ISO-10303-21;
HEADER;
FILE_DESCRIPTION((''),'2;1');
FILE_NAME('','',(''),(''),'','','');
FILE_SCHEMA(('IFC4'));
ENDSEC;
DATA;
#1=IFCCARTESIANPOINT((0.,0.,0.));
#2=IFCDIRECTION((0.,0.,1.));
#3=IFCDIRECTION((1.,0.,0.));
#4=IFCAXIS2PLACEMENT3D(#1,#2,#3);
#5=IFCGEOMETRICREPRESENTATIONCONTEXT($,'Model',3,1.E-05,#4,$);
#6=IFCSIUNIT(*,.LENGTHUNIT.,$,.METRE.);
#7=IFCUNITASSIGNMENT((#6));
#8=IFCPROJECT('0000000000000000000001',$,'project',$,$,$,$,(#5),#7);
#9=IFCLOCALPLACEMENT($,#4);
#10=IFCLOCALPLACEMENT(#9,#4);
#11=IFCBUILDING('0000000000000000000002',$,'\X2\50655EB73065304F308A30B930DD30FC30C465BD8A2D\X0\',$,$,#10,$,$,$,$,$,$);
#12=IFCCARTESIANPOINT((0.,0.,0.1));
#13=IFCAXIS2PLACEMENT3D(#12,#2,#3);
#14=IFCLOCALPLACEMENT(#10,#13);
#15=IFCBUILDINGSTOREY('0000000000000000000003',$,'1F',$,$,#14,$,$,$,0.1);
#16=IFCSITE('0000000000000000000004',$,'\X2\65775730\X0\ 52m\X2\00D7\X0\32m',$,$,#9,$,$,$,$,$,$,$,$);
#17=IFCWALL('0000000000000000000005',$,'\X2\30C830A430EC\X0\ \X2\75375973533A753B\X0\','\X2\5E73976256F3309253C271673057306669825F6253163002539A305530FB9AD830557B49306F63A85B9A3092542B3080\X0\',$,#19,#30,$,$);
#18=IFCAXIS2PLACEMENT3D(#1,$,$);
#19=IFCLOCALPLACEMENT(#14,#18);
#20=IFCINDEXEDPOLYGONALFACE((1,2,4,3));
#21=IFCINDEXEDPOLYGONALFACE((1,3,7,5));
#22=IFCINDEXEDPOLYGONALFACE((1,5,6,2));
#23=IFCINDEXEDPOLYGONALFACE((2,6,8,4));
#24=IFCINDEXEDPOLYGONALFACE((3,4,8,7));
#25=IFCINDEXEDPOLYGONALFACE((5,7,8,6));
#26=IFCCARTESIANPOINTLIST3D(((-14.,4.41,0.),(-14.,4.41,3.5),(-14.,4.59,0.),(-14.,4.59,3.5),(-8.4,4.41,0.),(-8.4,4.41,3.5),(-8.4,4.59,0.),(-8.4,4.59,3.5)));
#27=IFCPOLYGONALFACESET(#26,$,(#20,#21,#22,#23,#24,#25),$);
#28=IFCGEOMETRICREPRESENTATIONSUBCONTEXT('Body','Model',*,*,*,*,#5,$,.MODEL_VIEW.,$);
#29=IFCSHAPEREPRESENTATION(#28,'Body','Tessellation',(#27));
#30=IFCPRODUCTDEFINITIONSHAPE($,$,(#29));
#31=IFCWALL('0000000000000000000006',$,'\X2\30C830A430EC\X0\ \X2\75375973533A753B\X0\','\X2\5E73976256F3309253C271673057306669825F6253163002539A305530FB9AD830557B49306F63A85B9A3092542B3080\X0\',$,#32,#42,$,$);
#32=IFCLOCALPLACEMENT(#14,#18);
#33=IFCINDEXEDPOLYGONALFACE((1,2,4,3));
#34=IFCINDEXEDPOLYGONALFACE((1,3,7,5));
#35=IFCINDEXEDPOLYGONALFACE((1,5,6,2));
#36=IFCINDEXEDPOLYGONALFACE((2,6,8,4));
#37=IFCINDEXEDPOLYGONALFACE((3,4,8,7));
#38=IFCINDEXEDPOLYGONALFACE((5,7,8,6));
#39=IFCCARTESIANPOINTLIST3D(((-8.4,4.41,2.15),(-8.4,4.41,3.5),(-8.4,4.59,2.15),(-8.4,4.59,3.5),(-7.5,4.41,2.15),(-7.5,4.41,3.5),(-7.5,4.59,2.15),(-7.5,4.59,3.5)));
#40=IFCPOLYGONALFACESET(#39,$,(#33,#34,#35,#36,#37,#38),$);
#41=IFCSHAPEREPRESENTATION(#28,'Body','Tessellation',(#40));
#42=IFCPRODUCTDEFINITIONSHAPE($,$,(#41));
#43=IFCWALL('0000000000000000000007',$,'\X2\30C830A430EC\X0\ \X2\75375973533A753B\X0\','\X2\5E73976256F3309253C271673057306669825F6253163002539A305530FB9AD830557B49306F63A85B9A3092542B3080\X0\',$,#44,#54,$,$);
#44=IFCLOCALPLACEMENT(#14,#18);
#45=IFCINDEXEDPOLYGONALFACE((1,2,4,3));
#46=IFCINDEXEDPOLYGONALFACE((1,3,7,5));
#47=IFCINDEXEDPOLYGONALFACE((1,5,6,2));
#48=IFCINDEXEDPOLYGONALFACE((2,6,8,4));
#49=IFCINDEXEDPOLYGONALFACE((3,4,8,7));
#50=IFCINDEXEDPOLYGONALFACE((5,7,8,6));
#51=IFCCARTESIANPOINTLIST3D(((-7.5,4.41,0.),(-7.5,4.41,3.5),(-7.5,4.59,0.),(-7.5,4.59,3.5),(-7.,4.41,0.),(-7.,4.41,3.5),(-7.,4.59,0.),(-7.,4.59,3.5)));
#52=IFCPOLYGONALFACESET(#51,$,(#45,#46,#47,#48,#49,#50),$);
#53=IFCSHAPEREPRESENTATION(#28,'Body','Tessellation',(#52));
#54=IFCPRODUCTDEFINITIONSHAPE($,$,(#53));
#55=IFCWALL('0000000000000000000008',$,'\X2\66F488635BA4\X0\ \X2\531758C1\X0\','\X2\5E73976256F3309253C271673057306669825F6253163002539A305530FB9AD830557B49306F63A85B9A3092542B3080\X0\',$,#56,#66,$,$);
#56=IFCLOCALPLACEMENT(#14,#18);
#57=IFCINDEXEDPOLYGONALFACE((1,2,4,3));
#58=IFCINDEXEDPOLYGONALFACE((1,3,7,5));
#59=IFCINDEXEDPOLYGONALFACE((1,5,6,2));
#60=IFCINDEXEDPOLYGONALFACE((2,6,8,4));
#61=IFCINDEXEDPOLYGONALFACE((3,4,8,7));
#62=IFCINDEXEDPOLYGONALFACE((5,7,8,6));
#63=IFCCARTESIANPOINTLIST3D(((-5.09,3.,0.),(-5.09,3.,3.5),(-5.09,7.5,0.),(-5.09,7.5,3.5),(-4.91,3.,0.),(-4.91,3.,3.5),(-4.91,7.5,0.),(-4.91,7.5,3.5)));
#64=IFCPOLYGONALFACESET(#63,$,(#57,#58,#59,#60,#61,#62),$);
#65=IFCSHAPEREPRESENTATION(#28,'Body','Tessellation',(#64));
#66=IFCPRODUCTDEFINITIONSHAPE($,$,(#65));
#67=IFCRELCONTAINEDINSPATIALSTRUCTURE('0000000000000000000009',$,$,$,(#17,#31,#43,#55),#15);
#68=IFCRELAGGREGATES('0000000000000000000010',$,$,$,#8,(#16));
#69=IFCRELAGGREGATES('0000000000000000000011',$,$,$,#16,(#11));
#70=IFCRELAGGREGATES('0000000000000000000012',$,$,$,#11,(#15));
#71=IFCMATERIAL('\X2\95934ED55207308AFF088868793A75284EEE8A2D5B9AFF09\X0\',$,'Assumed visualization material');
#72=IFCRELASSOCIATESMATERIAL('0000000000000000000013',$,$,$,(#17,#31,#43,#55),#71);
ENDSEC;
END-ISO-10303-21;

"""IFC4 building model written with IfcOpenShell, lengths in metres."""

from ifc_helpers import new_model, si_unit, frame, origin_with_axes, place, context, subcontext, project, spatial, rectangle, extrude, material, element, save


model = new_model("IFC4")

# Units and contexts
model_context = context("Model", 3, precision=1e-05, world=origin_with_axes())
body_context = subcontext(model_context, "Body", "Model", "MODEL_VIEW")
ifc_project = project(units=[si_unit("LENGTHUNIT", "METRE")], contexts=[model_context])

# Site, building, storey
site_placement = place(None, origin_with_axes())
site = spatial("IfcSite", under=ifc_project, at=site_placement, Name="敷地 52m×32m")
building_placement = place(site_placement, origin_with_axes())
building = spatial("IfcBuilding", under=site, at=building_placement, Name="健康づくりスポーツ施設")
storey_placement = place(building_placement, frame((0.0, 0.0, 0.1), z_axis=(0.0, 0.0, 1.0), x_axis=(1.0, 0.0, 0.0)))
storey = spatial("IfcBuildingStorey", under=building, at=storey_placement, Name="1F", Elevation=0.1)

# Walls
ifc_material_1 = material(Name="間仕切り（表示用仮設定）", Category="Assumed visualization material")
wall_1_placement = place(storey_placement, frame((-11.2, 4.5, 0.0), z_axis=(0.0, 0.0, 1.0), x_axis=(1.0, 0.0, 0.0)))
element("IfcWall", 1, at=wall_1_placement, inside=storey, material=ifc_material_1, Name="トイレ 男女区画", Description="平面図を参照して概形化。厚さ・高さ等は推定を含む", context=body_context, shape_type="SweptSolid", body=[
    extrude(rectangle(XDim=5.6, YDim=0.18), origin_with_axes(), (0.0, 0.0, 1.0), 3.5),
])
wall_2_placement = place(storey_placement, frame((-7.95, 4.5, 2.15), z_axis=(0.0, 0.0, 1.0), x_axis=(1.0, 0.0, 0.0)))
element("IfcWall", 2, at=wall_2_placement, inside=storey, material=ifc_material_1, Name="トイレ 男女区画", Description="平面図を参照して概形化。厚さ・高さ等は推定を含む", context=body_context, shape_type="SweptSolid", body=[
    extrude(rectangle(XDim=0.9, YDim=0.18), origin_with_axes(), (0.0, 0.0, 1.0), 1.35),
])
wall_3_placement = place(storey_placement, frame((-7.25, 4.5, 0.0), z_axis=(0.0, 0.0, 1.0), x_axis=(1.0, 0.0, 0.0)))
element("IfcWall", 3, at=wall_3_placement, inside=storey, material=ifc_material_1, Name="トイレ 男女区画", Description="平面図を参照して概形化。厚さ・高さ等は推定を含む", context=body_context, shape_type="SweptSolid", body=[
    extrude(rectangle(XDim=0.5, YDim=0.18), origin_with_axes(), (0.0, 0.0, 1.0), 3.5),
])
wall_4_placement = place(storey_placement, frame((-5.0, 5.25, 0.0), z_axis=(0.0, 0.0, 1.0), x_axis=(1.0, 0.0, 0.0)))
element("IfcWall", 4, at=wall_4_placement, inside=storey, material=ifc_material_1, Name="更衣室 北壁", Description="平面図を参照して概形化。厚さ・高さ等は推定を含む", context=body_context, shape_type="SweptSolid", body=[
    extrude(rectangle(XDim=0.18, YDim=4.5), origin_with_axes(), (0.0, 0.0, 1.0), 3.5),
])

save(model, "model.ifc")
